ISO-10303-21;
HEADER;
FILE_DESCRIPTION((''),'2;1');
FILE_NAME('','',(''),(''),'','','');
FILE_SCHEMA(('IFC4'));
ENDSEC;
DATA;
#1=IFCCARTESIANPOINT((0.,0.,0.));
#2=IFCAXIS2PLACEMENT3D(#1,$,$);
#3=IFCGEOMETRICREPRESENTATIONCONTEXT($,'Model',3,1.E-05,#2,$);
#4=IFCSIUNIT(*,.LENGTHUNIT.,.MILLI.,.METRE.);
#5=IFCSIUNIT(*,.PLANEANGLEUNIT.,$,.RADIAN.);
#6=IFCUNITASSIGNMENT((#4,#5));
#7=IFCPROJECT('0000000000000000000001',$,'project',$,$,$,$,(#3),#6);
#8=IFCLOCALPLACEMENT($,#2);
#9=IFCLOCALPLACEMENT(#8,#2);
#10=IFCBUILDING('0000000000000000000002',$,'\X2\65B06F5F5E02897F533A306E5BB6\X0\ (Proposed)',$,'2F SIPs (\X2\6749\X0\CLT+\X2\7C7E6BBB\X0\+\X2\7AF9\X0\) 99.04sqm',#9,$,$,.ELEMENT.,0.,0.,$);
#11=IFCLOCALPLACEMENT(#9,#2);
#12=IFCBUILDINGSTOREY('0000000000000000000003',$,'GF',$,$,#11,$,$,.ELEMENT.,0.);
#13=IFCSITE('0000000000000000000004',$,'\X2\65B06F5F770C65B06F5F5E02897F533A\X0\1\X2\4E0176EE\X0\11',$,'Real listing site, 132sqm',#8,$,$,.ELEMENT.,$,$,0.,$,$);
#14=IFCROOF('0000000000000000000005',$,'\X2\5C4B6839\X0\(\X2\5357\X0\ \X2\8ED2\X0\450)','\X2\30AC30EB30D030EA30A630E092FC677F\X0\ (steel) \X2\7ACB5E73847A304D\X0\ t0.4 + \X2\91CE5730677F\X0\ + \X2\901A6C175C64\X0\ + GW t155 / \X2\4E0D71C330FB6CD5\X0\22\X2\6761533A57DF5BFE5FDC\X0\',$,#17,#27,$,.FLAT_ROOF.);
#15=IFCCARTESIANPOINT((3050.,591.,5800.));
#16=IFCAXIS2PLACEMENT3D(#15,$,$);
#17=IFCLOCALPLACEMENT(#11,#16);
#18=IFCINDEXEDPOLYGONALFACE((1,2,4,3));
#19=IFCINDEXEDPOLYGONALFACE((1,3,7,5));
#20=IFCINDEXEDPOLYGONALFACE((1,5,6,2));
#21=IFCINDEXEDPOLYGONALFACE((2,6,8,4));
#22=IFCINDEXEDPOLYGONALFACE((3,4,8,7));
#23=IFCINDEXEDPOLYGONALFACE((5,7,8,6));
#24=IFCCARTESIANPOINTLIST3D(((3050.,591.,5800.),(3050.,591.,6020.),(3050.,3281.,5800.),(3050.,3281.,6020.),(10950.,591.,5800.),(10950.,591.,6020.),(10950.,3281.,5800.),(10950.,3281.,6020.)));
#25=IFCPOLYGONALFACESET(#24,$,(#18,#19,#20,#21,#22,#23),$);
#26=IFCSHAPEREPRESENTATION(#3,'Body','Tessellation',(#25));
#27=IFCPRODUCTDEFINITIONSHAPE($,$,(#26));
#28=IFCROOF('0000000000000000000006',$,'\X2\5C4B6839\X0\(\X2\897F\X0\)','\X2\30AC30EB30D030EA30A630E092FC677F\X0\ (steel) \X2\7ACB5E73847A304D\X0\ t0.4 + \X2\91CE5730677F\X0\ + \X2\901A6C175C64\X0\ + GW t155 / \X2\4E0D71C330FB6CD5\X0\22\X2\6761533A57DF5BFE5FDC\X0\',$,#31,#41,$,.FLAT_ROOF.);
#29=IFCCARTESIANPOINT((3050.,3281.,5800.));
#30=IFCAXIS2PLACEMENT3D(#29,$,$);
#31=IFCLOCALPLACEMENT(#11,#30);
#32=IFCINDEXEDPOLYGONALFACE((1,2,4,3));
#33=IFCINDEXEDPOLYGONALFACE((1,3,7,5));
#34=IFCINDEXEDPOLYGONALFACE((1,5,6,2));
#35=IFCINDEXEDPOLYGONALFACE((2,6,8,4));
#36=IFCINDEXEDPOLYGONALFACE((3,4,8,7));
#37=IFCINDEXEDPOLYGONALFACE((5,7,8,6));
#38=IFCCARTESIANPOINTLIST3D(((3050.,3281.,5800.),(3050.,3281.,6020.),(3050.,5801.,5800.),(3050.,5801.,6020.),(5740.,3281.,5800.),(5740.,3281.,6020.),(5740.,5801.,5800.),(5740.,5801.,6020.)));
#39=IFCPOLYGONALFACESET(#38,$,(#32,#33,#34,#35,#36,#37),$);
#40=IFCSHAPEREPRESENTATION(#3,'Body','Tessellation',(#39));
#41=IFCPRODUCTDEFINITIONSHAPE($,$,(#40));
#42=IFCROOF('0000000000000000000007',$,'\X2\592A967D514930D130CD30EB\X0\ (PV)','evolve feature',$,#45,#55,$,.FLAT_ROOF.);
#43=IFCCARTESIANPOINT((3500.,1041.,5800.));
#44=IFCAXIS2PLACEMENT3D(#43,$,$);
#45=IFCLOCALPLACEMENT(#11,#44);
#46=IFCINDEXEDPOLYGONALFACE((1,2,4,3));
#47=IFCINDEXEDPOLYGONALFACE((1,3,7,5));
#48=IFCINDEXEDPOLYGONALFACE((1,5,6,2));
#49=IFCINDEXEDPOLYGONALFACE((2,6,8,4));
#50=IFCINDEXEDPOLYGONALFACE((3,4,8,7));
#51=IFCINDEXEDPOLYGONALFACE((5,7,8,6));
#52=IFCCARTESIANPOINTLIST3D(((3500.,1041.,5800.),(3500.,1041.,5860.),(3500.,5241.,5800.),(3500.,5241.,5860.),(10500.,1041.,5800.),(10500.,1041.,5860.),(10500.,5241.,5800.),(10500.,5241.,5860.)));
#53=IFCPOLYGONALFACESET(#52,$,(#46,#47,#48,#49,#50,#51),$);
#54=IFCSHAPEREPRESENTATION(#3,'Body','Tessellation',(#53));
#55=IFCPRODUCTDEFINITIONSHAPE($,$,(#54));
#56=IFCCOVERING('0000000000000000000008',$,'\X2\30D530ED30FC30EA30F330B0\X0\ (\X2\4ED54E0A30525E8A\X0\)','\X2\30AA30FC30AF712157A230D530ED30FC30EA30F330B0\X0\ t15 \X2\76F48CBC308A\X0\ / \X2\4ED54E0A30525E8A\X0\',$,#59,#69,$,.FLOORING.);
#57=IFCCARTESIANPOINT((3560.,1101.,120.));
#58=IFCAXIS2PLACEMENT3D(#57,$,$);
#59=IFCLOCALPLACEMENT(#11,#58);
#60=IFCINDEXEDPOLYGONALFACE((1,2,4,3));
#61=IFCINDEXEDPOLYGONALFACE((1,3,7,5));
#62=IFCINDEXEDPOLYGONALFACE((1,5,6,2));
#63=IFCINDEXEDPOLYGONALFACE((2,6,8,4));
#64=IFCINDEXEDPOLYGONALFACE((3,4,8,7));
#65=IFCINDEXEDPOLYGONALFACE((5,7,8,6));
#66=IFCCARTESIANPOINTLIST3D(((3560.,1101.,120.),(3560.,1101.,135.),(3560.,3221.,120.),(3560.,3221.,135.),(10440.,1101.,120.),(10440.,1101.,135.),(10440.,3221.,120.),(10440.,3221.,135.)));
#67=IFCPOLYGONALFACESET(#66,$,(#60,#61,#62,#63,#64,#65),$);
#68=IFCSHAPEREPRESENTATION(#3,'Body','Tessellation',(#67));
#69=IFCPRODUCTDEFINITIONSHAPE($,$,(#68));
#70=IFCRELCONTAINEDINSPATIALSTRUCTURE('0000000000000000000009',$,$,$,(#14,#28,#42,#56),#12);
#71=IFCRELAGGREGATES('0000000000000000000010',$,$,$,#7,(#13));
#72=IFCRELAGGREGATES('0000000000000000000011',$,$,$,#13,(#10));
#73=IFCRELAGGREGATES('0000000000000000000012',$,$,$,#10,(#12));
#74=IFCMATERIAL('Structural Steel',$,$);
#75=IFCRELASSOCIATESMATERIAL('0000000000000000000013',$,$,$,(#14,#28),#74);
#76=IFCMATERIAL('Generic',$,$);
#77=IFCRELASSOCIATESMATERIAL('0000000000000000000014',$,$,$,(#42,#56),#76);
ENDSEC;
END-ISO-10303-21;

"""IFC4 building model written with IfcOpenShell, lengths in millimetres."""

from ifc_helpers import new_model, si_unit, frame, frame_2d, origin, place, context, project, spatial, rectangle, extrude, material, element, save


model = new_model("IFC4")

# Units and contexts
model_context = context("Model", 3, precision=1e-05, world=origin())
ifc_project = project(units=[si_unit("LENGTHUNIT", "METRE", prefix="MILLI"), si_unit("PLANEANGLEUNIT", "RADIAN")], contexts=[model_context])

# Site, building, storey
site_placement = place(None, origin())
site = spatial("IfcSite", under=ifc_project, at=site_placement, Name="新潟県新潟市西区1丁目11", ObjectType="Real listing site, 132sqm", CompositionType="ELEMENT", RefElevation=0.0)
building_placement = place(site_placement, origin())
building = spatial("IfcBuilding", under=site, at=building_placement, Name="新潟市西区の家 (Proposed)", ObjectType="2F SIPs (杉CLT+籾殻+竹) 99.04sqm", CompositionType="ELEMENT", ElevationOfRefHeight=0.0, ElevationOfTerrain=0.0)
storey_placement = place(building_placement, origin())
storey = spatial("IfcBuildingStorey", under=building, at=storey_placement, Name="GF", CompositionType="ELEMENT", Elevation=0.0)

# Shared definitions
ifc_material_1 = material(Name="Generic")

# Roofs
ifc_material_2 = material(Name="Structural Steel")
roof_1_placement = place(storey_placement, frame((3050.0, 591.0, 5800.0)))
element("IfcRoof", 1, at=roof_1_placement, inside=storey, material=ifc_material_2, Name="屋根(南 軒450)", Description="ガルバリウム鋼板 (steel) 立平葺き t0.4 + 野地板 + 通気層 + GW t155 / 不燃・法22条区域対応", PredefinedType="FLAT_ROOF", context=model_context, shape_type="SweptSolid", body=[
    extrude(rectangle(XDim=7900.0, YDim=2690.0, at=frame_2d((3950.0, 1345.0))), frame((3050.0, 591.0, 5800.0)), (0.0, 0.0, 1.0), 220.0),
])
roof_2_placement = place(storey_placement, frame((3050.0, 3281.0, 5800.0)))
element("IfcRoof", 2, at=roof_2_placement, inside=storey, material=ifc_material_2, Name="屋根(西)", Description="ガルバリウム鋼板 (steel) 立平葺き t0.4 + 野地板 + 通気層 + GW t155 / 不燃・法22条区域対応", PredefinedType="FLAT_ROOF", context=model_context, shape_type="SweptSolid", body=[
    extrude(rectangle(XDim=2690.0, YDim=2520.0, at=frame_2d((1345.0, 1260.0))), frame((3050.0, 3281.0, 5800.0)), (0.0, 0.0, 1.0), 220.0),
])
roof_3_placement = place(storey_placement, frame((3500.0, 1041.0, 5800.0)))
element("IfcRoof", 3, at=roof_3_placement, inside=storey, material=ifc_material_1, Name="太陽光パネル (PV)", Description="evolve feature", PredefinedType="FLAT_ROOF", context=model_context, shape_type="SweptSolid", body=[
    extrude(rectangle(XDim=7000.0, YDim=4200.0, at=frame_2d((3500.0, 2100.0))), frame((3500.0, 1041.0, 5800.0)), (0.0, 0.0, 1.0), 60.0),
])

# Covering
covering_placement = place(storey_placement, frame((3560.0, 1101.0, 120.0)))
element("IfcCovering", 4, at=covering_placement, inside=storey, material=ifc_material_1, Name="フローリング (仕上げ床)", Description="オーク無垢フローリング t15 直貼り / 仕上げ床", PredefinedType="FLOORING", context=model_context, shape_type="SweptSolid", body=[
    extrude(rectangle(XDim=6880.0, YDim=2120.0, at=frame_2d((3440.0, 1060.0))), frame((3560.0, 1101.0, 120.0)), (0.0, 0.0, 1.0), 15.0),
])

save(model, "model.ifc")
